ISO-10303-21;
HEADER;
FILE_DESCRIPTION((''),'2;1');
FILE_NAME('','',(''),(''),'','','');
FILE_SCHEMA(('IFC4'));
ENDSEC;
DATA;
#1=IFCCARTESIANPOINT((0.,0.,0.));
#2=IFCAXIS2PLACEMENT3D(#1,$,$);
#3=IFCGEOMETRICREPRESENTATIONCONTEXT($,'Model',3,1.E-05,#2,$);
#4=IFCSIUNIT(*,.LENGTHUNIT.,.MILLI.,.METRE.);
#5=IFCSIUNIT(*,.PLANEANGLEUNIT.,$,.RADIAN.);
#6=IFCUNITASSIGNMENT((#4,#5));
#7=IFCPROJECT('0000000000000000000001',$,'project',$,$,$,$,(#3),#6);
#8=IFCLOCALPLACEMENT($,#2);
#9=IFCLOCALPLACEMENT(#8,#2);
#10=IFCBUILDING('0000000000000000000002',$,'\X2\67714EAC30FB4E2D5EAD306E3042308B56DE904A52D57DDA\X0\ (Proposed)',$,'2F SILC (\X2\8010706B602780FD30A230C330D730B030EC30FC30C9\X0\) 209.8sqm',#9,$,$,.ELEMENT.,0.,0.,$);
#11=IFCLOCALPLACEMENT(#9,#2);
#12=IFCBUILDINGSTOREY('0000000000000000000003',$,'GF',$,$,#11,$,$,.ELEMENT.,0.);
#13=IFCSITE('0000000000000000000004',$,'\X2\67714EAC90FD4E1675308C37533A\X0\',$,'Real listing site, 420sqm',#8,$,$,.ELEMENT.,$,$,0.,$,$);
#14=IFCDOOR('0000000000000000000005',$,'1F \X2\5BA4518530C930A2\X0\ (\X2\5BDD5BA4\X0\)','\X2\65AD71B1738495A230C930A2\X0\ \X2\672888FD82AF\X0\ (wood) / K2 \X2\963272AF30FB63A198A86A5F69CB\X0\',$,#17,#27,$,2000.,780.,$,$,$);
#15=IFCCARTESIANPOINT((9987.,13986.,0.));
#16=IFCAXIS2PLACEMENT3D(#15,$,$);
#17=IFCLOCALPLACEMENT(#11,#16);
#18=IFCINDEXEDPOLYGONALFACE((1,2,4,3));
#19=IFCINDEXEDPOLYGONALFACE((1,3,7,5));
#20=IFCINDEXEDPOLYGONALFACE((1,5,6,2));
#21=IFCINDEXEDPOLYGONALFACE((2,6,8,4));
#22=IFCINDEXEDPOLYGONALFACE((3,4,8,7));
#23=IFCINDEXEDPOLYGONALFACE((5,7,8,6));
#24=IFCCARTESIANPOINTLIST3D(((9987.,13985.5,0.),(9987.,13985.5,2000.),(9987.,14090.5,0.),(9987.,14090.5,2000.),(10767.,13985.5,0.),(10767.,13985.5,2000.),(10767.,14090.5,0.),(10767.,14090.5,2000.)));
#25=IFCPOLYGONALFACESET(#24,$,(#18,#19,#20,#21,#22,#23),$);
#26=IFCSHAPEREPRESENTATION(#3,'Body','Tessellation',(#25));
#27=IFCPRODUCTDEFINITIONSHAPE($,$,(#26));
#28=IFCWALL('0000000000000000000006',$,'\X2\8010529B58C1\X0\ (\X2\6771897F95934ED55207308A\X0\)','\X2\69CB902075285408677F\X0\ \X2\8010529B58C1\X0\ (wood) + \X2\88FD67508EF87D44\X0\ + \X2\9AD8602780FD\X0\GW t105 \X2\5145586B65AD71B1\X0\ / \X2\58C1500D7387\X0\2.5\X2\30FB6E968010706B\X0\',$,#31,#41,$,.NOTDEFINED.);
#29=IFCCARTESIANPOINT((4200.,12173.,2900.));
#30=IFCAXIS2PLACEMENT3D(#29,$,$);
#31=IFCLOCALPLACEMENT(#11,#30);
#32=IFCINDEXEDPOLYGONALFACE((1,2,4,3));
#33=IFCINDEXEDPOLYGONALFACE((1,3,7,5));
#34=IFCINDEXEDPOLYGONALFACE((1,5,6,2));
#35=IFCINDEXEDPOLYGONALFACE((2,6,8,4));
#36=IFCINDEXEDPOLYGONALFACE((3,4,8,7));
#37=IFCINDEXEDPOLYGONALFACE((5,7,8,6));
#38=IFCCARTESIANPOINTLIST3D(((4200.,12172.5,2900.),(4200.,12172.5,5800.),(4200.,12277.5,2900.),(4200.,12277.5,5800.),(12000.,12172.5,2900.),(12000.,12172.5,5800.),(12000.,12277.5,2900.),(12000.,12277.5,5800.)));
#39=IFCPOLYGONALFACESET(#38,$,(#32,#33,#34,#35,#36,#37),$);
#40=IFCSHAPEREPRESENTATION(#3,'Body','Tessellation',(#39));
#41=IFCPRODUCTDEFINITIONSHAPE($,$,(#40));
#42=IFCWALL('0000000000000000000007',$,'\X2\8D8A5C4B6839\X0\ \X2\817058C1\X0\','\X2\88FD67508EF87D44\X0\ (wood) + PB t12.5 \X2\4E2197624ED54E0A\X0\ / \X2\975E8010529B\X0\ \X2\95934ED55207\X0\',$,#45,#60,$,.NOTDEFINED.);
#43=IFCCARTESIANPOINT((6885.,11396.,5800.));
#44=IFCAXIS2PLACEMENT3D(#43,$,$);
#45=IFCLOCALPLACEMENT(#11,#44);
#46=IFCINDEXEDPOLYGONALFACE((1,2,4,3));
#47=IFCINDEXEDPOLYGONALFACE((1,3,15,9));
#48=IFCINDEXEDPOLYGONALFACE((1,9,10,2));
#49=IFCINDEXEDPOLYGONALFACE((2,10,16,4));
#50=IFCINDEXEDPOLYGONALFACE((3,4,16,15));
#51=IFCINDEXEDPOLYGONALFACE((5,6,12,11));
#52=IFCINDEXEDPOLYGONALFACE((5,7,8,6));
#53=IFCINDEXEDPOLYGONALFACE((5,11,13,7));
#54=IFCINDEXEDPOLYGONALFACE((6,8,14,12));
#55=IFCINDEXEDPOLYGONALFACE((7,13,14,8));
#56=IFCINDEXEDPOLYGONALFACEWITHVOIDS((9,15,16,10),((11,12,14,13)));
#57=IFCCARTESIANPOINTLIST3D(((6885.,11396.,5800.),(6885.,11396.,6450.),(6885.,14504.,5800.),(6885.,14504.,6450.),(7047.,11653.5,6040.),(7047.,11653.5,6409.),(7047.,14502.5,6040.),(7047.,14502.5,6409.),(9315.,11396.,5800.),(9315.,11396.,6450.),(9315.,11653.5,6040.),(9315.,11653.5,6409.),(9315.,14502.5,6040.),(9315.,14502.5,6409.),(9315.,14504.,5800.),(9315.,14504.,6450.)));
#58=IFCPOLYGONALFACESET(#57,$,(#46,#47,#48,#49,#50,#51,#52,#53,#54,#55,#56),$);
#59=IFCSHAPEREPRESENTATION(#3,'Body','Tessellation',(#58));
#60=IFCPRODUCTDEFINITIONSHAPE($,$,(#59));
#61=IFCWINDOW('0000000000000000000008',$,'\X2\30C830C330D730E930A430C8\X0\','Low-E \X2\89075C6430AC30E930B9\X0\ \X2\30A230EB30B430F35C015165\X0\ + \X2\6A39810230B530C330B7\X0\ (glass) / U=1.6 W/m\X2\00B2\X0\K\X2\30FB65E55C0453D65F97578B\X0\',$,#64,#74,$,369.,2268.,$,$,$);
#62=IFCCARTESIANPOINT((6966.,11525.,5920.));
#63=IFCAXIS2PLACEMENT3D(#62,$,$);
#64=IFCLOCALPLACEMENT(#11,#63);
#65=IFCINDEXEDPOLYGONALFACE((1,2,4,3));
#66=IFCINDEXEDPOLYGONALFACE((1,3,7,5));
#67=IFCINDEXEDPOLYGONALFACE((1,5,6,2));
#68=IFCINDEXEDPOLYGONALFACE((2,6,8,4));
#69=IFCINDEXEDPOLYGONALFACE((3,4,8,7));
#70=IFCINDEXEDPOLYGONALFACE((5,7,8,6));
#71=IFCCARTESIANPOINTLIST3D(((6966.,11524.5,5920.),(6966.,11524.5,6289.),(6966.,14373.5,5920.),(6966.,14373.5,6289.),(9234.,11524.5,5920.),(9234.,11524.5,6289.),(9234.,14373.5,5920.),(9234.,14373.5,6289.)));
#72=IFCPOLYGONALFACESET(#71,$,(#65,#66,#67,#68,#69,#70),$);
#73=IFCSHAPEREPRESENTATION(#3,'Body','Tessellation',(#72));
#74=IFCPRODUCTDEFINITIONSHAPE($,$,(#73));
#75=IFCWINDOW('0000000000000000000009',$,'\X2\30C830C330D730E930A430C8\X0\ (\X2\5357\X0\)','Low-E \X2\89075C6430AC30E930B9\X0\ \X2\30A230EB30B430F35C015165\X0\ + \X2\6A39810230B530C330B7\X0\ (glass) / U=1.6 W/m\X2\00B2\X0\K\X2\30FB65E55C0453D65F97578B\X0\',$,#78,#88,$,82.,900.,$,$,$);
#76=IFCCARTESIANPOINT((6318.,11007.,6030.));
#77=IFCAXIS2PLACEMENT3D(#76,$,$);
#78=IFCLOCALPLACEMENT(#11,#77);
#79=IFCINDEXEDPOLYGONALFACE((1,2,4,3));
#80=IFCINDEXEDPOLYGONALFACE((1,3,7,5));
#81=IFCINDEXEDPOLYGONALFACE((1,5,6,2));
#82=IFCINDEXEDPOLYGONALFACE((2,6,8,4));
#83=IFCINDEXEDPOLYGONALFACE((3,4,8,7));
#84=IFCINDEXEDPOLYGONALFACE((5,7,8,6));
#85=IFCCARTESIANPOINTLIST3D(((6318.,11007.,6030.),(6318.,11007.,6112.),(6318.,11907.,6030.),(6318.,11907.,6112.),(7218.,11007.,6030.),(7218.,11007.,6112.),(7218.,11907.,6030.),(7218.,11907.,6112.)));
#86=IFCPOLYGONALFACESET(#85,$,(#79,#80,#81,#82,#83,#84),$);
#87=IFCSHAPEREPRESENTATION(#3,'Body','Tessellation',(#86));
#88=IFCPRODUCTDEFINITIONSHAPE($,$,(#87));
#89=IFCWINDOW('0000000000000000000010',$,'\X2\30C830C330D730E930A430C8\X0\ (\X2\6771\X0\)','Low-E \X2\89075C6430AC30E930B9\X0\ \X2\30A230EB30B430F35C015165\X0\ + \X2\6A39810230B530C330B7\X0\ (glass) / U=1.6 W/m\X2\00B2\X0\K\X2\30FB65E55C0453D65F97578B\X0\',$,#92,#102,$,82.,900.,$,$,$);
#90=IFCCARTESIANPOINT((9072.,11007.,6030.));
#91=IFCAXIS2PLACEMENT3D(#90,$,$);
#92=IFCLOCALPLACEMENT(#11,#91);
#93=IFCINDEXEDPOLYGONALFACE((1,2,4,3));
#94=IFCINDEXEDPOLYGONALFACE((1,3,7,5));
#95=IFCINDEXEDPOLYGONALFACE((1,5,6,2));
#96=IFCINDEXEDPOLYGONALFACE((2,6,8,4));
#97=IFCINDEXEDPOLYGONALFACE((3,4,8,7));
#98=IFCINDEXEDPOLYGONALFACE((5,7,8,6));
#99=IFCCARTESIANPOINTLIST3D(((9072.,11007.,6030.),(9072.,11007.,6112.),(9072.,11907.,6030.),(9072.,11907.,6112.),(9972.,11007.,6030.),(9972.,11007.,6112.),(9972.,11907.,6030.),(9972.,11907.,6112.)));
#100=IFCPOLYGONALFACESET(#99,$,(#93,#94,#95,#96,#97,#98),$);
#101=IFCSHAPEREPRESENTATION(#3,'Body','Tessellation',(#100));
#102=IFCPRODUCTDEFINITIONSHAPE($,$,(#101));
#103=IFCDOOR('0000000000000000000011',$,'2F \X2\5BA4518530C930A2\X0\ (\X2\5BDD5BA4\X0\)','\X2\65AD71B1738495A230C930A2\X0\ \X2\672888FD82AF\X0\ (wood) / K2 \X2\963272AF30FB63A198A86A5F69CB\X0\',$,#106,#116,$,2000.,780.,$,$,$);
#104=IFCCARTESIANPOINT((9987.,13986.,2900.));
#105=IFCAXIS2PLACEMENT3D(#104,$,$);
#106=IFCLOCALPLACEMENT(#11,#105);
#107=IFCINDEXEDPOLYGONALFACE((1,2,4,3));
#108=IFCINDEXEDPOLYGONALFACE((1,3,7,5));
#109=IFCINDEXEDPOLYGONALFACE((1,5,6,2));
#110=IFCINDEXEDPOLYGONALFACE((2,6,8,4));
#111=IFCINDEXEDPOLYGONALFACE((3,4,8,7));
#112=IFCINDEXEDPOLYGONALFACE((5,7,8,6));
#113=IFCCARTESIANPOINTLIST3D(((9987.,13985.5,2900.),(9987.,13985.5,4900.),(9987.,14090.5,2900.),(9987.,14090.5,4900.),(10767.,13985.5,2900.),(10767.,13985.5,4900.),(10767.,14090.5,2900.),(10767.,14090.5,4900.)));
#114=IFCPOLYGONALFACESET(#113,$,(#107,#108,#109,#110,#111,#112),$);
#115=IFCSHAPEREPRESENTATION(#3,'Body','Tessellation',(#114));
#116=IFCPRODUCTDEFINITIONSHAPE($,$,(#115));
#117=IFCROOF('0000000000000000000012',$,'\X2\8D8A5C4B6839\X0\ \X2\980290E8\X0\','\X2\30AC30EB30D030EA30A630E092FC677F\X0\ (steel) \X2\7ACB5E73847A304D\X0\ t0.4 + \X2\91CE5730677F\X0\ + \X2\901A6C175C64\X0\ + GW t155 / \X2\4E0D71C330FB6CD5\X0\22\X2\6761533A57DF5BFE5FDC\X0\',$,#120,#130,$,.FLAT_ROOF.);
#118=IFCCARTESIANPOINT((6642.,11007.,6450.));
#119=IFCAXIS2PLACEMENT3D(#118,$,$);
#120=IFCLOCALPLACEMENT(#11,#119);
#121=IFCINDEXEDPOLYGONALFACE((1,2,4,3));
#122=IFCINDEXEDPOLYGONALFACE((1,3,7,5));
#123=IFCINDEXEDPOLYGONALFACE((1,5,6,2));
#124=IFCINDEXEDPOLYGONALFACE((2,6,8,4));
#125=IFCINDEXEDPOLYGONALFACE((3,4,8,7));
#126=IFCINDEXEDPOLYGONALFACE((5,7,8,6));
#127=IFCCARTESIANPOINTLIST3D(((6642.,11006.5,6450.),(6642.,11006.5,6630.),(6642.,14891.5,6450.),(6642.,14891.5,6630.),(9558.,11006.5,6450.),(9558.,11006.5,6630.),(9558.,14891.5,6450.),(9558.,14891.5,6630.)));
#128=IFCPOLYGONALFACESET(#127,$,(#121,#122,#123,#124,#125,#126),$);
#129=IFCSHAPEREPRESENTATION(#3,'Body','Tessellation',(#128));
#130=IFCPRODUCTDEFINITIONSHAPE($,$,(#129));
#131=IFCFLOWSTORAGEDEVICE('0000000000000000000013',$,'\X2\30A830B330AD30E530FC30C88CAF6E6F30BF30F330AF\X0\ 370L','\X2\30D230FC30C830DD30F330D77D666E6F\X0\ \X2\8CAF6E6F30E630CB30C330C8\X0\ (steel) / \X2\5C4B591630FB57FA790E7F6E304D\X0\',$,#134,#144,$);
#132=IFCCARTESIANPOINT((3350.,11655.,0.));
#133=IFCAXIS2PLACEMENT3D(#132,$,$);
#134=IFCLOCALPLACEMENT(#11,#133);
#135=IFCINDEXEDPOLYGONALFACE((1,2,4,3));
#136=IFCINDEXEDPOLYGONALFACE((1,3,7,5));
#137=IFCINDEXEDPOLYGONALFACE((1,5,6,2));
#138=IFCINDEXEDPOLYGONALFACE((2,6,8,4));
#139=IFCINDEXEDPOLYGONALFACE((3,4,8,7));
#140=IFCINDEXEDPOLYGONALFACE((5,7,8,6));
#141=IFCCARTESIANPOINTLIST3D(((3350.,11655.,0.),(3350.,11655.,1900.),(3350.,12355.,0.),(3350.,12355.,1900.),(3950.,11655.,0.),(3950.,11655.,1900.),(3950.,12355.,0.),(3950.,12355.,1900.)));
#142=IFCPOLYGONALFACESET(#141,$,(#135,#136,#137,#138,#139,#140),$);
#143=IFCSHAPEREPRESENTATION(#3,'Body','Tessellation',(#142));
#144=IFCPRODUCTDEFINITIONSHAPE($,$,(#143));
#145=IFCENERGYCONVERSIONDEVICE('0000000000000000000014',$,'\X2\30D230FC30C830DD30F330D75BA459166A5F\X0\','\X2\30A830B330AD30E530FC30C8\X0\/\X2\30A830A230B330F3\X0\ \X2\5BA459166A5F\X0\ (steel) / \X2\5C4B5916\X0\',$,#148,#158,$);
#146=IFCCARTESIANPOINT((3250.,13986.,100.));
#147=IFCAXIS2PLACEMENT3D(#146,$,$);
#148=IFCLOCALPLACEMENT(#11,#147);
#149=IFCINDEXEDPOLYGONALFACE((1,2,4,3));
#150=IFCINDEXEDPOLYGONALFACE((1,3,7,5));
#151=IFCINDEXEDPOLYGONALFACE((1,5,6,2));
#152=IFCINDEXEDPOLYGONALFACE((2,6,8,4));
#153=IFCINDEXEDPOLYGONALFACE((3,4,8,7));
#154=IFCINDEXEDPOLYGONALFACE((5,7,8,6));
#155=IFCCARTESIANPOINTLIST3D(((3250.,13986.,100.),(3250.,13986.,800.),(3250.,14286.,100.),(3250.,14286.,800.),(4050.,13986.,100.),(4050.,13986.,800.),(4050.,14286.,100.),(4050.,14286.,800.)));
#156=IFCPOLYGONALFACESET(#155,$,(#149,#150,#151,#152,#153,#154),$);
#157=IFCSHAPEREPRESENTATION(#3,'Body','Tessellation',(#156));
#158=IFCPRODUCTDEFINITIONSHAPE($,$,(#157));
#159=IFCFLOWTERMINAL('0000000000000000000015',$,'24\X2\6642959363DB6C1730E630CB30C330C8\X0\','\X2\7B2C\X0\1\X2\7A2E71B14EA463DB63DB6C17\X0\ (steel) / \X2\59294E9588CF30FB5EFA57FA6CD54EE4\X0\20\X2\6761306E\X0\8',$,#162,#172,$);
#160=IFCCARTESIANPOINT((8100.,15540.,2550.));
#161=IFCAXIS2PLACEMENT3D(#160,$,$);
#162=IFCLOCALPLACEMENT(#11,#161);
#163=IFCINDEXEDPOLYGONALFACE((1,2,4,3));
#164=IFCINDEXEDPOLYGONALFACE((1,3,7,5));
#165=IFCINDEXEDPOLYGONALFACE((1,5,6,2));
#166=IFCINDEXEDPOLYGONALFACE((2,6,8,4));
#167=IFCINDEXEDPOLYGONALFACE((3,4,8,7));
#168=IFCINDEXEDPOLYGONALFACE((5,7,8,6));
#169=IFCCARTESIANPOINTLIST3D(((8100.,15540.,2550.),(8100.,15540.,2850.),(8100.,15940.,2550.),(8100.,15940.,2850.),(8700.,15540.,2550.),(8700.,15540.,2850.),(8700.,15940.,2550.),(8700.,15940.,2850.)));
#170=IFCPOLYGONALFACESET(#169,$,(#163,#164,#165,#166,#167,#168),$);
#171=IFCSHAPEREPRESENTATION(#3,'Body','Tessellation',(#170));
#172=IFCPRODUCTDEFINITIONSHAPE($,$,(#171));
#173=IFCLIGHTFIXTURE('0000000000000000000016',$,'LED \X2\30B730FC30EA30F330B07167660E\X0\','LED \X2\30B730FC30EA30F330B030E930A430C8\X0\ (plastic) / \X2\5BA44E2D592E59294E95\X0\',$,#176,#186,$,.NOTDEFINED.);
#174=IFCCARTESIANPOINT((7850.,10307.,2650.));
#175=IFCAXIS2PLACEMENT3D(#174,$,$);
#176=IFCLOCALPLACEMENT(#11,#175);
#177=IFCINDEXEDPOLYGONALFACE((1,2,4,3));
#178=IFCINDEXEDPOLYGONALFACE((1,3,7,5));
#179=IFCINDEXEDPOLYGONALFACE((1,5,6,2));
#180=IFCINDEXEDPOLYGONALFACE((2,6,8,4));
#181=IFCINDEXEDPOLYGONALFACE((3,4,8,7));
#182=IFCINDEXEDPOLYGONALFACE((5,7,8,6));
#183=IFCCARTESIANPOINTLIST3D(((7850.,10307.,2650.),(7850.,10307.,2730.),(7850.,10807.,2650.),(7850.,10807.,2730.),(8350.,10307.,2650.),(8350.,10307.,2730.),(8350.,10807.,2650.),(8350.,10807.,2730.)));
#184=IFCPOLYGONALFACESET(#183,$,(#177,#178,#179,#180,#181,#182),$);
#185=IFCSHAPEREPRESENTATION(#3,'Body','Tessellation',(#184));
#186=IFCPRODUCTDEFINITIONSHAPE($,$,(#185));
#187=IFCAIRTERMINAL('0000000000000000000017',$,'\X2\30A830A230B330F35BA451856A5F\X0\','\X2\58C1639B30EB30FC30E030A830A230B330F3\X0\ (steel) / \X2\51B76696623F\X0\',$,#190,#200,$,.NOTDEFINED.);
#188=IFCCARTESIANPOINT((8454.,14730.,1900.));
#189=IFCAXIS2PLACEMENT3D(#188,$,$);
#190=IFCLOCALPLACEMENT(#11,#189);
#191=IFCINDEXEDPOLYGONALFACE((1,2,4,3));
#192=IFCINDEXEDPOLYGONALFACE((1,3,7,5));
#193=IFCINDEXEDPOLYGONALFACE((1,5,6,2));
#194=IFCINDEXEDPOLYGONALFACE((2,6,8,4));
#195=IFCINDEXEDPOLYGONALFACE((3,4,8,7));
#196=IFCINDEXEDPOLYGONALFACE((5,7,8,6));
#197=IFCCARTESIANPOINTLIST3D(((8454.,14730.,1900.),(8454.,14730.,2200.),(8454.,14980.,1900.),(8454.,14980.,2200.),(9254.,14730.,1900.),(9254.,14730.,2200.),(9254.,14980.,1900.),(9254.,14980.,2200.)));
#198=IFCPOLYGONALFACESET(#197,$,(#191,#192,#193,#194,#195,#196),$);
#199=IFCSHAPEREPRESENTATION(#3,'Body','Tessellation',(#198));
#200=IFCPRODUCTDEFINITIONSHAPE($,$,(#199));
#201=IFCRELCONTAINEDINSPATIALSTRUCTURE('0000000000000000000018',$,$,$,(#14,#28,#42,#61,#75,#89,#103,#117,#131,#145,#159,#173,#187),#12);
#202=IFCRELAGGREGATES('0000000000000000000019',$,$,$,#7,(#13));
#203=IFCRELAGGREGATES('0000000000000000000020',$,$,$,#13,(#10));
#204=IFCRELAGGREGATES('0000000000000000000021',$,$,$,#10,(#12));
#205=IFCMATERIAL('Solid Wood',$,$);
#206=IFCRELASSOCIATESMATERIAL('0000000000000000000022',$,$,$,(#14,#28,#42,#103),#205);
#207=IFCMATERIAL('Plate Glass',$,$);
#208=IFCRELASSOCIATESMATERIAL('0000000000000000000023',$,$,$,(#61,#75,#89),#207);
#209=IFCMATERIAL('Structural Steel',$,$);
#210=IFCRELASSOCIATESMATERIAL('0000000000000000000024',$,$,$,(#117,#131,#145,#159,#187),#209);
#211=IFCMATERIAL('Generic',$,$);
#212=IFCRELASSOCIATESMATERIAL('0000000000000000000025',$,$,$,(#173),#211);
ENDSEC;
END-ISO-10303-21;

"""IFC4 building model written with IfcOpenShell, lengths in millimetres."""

from ifc_helpers import new_model, si_unit, frame, frame_2d, origin, place, context, project, spatial, rectangle, extrude, material, element, fill, save


model = new_model("IFC4")

# Units and contexts
model_context = context("Model", 3, precision=1e-05, world=origin())
ifc_project = project(units=[si_unit("LENGTHUNIT", "METRE", prefix="MILLI"), si_unit("PLANEANGLEUNIT", "RADIAN")], contexts=[model_context])

# Site, building, storey
site_placement = place(None, origin())
site = spatial("IfcSite", under=ifc_project, at=site_placement, Name="東京都世田谷区", ObjectType="Real listing site, 420sqm", CompositionType="ELEMENT", RefElevation=0.0)
building_placement = place(site_placement, origin())
building = spatial("IfcBuilding", under=site, at=building_placement, Name="東京・中庭のある回遊動線 (Proposed)", ObjectType="2F SILC (耐火性能アップグレード) 209.8sqm", CompositionType="ELEMENT", ElevationOfRefHeight=0.0, ElevationOfTerrain=0.0)
storey_placement = place(building_placement, origin())
storey = spatial("IfcBuildingStorey", under=building, at=storey_placement, Name="GF", CompositionType="ELEMENT", Elevation=0.0)

# Shared definitions
ifc_material_1 = material(Name="Solid Wood")

# Door
door_1_placement = place(storey_placement, frame((9987.0, 13986.0, 0.0)))
element("IfcDoor", 1, at=door_1_placement, inside=storey, material=ifc_material_1, Name="1F 室内ドア (寝室)", Description="断熱玄関ドア 木製芯 (wood) / K2 防犯・採風機構", OverallHeight=2000.0, OverallWidth=780.0, context=model_context, shape_type="SweptSolid", body=[
    extrude(rectangle(XDim=780.0, YDim=105.0, at=frame_2d((390.0, 52.0))), frame((9987.0, 13986.0, 0.0)), (0.0, 0.0, 1.0), 2000.0),
])

# Wall
wall_1_placement = place(storey_placement, frame((4200.0, 12173.0, 2900.0)))
element("IfcWall", 2, at=wall_1_placement, inside=storey, material=ifc_material_1, Name="耐力壁 (東西間仕切り)", Description="構造用合板 耐力壁 (wood) + 製材軸組 + 高性能GW t105 充填断熱 / 壁倍率2.5・準耐火", PredefinedType="NOTDEFINED", context=model_context, shape_type="SweptSolid", body=[
    extrude(rectangle(XDim=7800.0, YDim=105.0, at=frame_2d((3900.0, 52.0))), frame((4200.0, 12173.0, 2900.0)), (0.0, 0.0, 1.0), 2900.0),
])

# Wall, openings, windows
wall_2_placement = place(storey_placement, frame((6885.0, 11396.0, 5800.0)))
wall_2 = element("IfcWall", 3, at=wall_2_placement, inside=storey, material=ifc_material_1, Name="越屋根 腰壁", Description="製材軸組 (wood) + PB t12.5 両面仕上 / 非耐力 間仕切", PredefinedType="NOTDEFINED", context=model_context, shape_type="SweptSolid", body=[
    extrude(rectangle(XDim=2430.0, YDim=3108.0, at=frame_2d((1215.0, 1554.0))), frame((6885.0, 11396.0, 5800.0)), (0.0, 0.0, 1.0), 650.0),
])
opening_1_placement = place(storey_placement, frame((6966.0, 11525.0, 5920.0)))
opening_1 = element("IfcOpeningElement", 4, at=opening_1_placement, cuts=wall_2, PredefinedType="NOTDEFINED", context=model_context, shape_type="SweptSolid", body=[
    extrude(rectangle(XDim=2268.0, YDim=2849.0, at=frame_2d((1134.0, 1424.0))), frame((6966.0, 11525.0, 5920.0)), (0.0, 0.0, 1.0), 369.0),
])
opening_2_placement = place(storey_placement, frame((6318.0, 11007.0, 6030.0)))
opening_2 = element("IfcOpeningElement", 5, at=opening_2_placement, cuts=wall_2, PredefinedType="NOTDEFINED", context=model_context, shape_type="SweptSolid", body=[
    extrude(rectangle(XDim=900.0, YDim=900.0, at=frame_2d((450.0, 450.0))), frame((6318.0, 11007.0, 6030.0)), (0.0, 0.0, 1.0), 82.0),
])
opening_3_placement = place(storey_placement, frame((9072.0, 11007.0, 6030.0)))
opening_3 = element("IfcOpeningElement", 6, at=opening_3_placement, cuts=wall_2, PredefinedType="NOTDEFINED", context=model_context, shape_type="SweptSolid", body=[
    extrude(rectangle(XDim=900.0, YDim=900.0, at=frame_2d((450.0, 450.0))), frame((9072.0, 11007.0, 6030.0)), (0.0, 0.0, 1.0), 82.0),
])
ifc_material_2 = material(Name="Plate Glass")
window_1_placement = place(storey_placement, frame((6966.0, 11525.0, 5920.0)))
window_1 = element("IfcWindow", 7, at=window_1_placement, inside=storey, material=ifc_material_2, Name="トップライト", Description="Low-E 複層ガラス アルゴン封入 + 樹脂サッシ (glass) / U=1.6 W/m²K・日射取得型", OverallHeight=369.0, OverallWidth=2268.0, context=model_context, shape_type="SweptSolid", body=[
    extrude(rectangle(XDim=2268.0, YDim=2849.0, at=frame_2d((1134.0, 1424.0))), frame((6966.0, 11525.0, 5920.0)), (0.0, 0.0, 1.0), 369.0),
])
fill(opening_1, window_1)
window_2_placement = place(storey_placement, frame((6318.0, 11007.0, 6030.0)))
window_2 = element("IfcWindow", 8, at=window_2_placement, inside=storey, material=ifc_material_2, Name="トップライト (南)", Description="Low-E 複層ガラス アルゴン封入 + 樹脂サッシ (glass) / U=1.6 W/m²K・日射取得型", OverallHeight=82.0, OverallWidth=900.0, context=model_context, shape_type="SweptSolid", body=[
    extrude(rectangle(XDim=900.0, YDim=900.0, at=frame_2d((450.0, 450.0))), frame((6318.0, 11007.0, 6030.0)), (0.0, 0.0, 1.0), 82.0),
])
fill(opening_2, window_2)
window_3_placement = place(storey_placement, frame((9072.0, 11007.0, 6030.0)))
window_3 = element("IfcWindow", 9, at=window_3_placement, inside=storey, material=ifc_material_2, Name="トップライト (東)", Description="Low-E 複層ガラス アルゴン封入 + 樹脂サッシ (glass) / U=1.6 W/m²K・日射取得型", OverallHeight=82.0, OverallWidth=900.0, context=model_context, shape_type="SweptSolid", body=[
    extrude(rectangle(XDim=900.0, YDim=900.0, at=frame_2d((450.0, 450.0))), frame((9072.0, 11007.0, 6030.0)), (0.0, 0.0, 1.0), 82.0),
])
fill(opening_3, window_3)

# Door
door_2_placement = place(storey_placement, frame((9987.0, 13986.0, 2900.0)))
element("IfcDoor", 10, at=door_2_placement, inside=storey, material=ifc_material_1, Name="2F 室内ドア (寝室)", Description="断熱玄関ドア 木製芯 (wood) / K2 防犯・採風機構", OverallHeight=2000.0, OverallWidth=780.0, context=model_context, shape_type="SweptSolid", body=[
    extrude(rectangle(XDim=780.0, YDim=105.0, at=frame_2d((390.0, 52.0))), frame((9987.0, 13986.0, 2900.0)), (0.0, 0.0, 1.0), 2000.0),
])

# Roof
ifc_material_3 = material(Name="Structural Steel")
roof_placement = place(storey_placement, frame((6642.0, 11007.0, 6450.0)))
element("IfcRoof", 11, at=roof_placement, inside=storey, material=ifc_material_3, Name="越屋根 頂部", Description="ガルバリウム鋼板 (steel) 立平葺き t0.4 + 野地板 + 通気層 + GW t155 / 不燃・法22条区域対応", PredefinedType="FLAT_ROOF", context=model_context, shape_type="SweptSolid", body=[
    extrude(rectangle(XDim=2916.0, YDim=3885.0, at=frame_2d((1458.0, 1942.0))), frame((6642.0, 11007.0, 6450.0)), (0.0, 0.0, 1.0), 180.0),
])

# Flow storage device
flow_storage_device_placement = place(storey_placement, frame((3350.0, 11655.0, 0.0)))
element("IfcFlowStorageDevice", 12, at=flow_storage_device_placement, inside=storey, material=ifc_material_3, Name="エコキュート貯湯タンク 370L", Description="ヒートポンプ給湯 貯湯ユニット (steel) / 屋外・基礎置き", context=model_context, shape_type="SweptSolid", body=[
    extrude(rectangle(XDim=600.0, YDim=700.0, at=frame_2d((300.0, 350.0))), frame((3350.0, 11655.0, 0.0)), (0.0, 0.0, 1.0), 1900.0),
])

# Energy conversion device
energy_conversion_device_placement = place(storey_placement, frame((3250.0, 13986.0, 100.0)))
element("IfcEnergyConversionDevice", 13, at=energy_conversion_device_placement, inside=storey, material=ifc_material_3, Name="ヒートポンプ室外機", Description="エコキュート/エアコン 室外機 (steel) / 屋外", context=model_context, shape_type="SweptSolid", body=[
    extrude(rectangle(XDim=800.0, YDim=300.0, at=frame_2d((400.0, 150.0))), frame((3250.0, 13986.0, 100.0)), (0.0, 0.0, 1.0), 700.0),
])

# Flow terminal
flow_terminal_placement = place(storey_placement, frame((8100.0, 15540.0, 2550.0)))
element("IfcFlowTerminal", 14, at=flow_terminal_placement, inside=storey, material=ifc_material_3, Name="24時間換気ユニット", Description="第1種熱交換換気 (steel) / 天井裏・建基法令20条の8", context=model_context, shape_type="SweptSolid", body=[
    extrude(rectangle(XDim=600.0, YDim=400.0, at=frame_2d((300.0, 200.0))), frame((8100.0, 15540.0, 2550.0)), (0.0, 0.0, 1.0), 300.0),
])

# Light fixture
ifc_material_4 = material(Name="Generic")
light_fixture_1_placement = place(storey_placement, frame((7850.0, 10307.0, 2650.0)))
element("IfcLightFixture", 15, at=light_fixture_1_placement, inside=storey, material=ifc_material_4, Name="LED シーリング照明", Description="LED シーリングライト (plastic) / 室中央天井", PredefinedType="NOTDEFINED", context=model_context, shape_type="SweptSolid", body=[
    extrude(rectangle(XDim=500.0, YDim=500.0, at=frame_2d((250.0, 250.0))), frame((7850.0, 10307.0, 2650.0)), (0.0, 0.0, 1.0), 80.0),
])

# Air terminal
air_terminal_placement = place(storey_placement, frame((8454.0, 14730.0, 1900.0)))
element("IfcAirTerminal", 16, at=air_terminal_placement, inside=storey, material=ifc_material_3, Name="エアコン室内機", Description="壁掛ルームエアコン (steel) / 冷暖房", PredefinedType="NOTDEFINED", context=model_context, shape_type="SweptSolid", body=[
    extrude(rectangle(XDim=800.0, YDim=250.0, at=frame_2d((400.0, 125.0))), frame((8454.0, 14730.0, 1900.0)), (0.0, 0.0, 1.0), 300.0),
])

save(model, "model.ifc")
